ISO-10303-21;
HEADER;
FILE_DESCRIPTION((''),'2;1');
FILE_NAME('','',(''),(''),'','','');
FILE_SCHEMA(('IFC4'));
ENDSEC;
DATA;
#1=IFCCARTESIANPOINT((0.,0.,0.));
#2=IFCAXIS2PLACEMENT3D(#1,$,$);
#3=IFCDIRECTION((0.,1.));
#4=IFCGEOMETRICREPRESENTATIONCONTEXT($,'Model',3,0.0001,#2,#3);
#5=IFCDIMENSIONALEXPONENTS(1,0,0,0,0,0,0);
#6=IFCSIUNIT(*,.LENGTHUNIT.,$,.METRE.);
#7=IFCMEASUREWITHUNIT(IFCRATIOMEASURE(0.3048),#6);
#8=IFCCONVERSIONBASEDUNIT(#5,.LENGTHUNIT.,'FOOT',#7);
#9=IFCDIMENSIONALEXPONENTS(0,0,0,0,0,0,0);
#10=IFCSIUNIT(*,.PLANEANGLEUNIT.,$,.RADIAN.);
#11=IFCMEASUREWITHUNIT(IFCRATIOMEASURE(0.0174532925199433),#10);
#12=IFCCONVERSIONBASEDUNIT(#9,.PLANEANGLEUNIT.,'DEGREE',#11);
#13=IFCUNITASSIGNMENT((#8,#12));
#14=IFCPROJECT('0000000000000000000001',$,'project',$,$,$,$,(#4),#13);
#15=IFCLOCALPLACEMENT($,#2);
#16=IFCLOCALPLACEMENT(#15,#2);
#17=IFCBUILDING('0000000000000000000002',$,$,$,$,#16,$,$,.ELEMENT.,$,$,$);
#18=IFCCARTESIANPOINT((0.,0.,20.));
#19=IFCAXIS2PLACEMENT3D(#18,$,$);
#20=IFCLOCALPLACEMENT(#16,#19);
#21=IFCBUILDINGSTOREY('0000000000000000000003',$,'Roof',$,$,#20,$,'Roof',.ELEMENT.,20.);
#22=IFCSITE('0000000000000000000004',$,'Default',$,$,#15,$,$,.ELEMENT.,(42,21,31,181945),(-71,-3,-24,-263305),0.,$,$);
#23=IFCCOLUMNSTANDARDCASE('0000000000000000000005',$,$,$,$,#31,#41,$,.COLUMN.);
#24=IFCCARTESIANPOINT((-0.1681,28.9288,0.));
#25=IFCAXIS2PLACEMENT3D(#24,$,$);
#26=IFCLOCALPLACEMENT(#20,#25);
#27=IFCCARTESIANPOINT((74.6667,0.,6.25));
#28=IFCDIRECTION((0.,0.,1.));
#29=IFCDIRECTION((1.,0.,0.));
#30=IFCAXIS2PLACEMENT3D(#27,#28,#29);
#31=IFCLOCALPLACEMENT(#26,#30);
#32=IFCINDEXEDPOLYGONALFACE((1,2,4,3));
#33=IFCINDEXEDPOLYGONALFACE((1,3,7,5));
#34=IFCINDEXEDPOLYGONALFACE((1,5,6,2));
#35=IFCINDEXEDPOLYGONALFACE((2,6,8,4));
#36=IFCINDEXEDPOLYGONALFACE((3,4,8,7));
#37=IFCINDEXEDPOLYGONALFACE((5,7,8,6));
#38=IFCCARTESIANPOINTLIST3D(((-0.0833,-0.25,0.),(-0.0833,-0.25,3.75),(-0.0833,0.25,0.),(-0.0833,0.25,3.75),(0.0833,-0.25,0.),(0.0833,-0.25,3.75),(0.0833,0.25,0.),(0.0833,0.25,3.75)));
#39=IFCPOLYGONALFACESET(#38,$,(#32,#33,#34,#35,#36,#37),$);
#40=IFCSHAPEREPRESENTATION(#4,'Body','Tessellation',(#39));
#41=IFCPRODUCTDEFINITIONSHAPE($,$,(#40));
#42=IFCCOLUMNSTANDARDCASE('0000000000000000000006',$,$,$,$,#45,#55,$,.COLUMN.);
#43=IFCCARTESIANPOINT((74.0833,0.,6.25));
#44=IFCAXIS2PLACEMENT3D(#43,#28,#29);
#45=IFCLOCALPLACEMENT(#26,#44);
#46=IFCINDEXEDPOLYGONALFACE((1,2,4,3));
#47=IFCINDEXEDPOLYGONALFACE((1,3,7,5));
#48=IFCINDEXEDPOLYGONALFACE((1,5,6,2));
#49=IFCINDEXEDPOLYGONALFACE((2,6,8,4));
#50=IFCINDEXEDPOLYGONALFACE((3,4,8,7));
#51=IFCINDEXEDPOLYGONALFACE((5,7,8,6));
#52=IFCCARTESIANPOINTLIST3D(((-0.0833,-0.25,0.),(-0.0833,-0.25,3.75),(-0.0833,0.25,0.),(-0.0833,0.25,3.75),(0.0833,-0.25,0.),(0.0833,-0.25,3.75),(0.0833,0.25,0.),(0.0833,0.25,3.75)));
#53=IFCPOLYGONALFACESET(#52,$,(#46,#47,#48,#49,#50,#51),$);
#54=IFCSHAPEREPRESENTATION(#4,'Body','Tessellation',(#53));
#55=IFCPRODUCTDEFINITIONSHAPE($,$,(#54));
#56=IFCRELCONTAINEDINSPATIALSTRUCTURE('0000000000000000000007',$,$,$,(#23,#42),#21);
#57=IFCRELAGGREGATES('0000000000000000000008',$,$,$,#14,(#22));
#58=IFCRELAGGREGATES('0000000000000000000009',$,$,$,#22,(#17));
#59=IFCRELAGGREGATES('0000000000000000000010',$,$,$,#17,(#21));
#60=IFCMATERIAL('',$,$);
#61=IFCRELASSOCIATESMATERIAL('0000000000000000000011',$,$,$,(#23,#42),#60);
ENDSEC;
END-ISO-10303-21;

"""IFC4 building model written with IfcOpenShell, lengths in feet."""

from ifc_helpers import new_model, entity, si_unit, converted_unit, direction, frame, origin, place, context, project, spatial, rectangle, extrude, material, element, save


model = new_model("IFC4")

# Units and contexts
model_context = context("Model", 3, precision=0.0001, world=origin(), true_north=direction((0.0, 1.0)))
ifc_project = project(units=[converted_unit("LENGTHUNIT", "FOOT", entity("IfcRatioMeasure", 0.3048), si_unit("LENGTHUNIT", "METRE"), dimensions=[1, 0, 0, 0, 0, 0, 0]), converted_unit("PLANEANGLEUNIT", "DEGREE", entity("IfcRatioMeasure", 0.0174532925199433), si_unit("PLANEANGLEUNIT", "RADIAN"), dimensions=[0, 0, 0, 0, 0, 0, 0])], contexts=[model_context])

# Site, building, storey
site_placement = place(None, origin())
site = spatial("IfcSite", under=ifc_project, at=site_placement, Name="Default", CompositionType="ELEMENT", RefLatitude=(42, 21, 31, 181945), RefLongitude=(-71, -3, -24, -263305), RefElevation=0.0)
building_placement = place(site_placement, origin())
building = spatial("IfcBuilding", under=site, at=building_placement, CompositionType="ELEMENT")
storey_placement = place(building_placement, frame((0.0, 0.0, 20.0)))
storey = spatial("IfcBuildingStorey", under=building, at=storey_placement, Name="Roof", LongName="Roof", CompositionType="ELEMENT", Elevation=20.0)

# Columns
ifc_material_1 = material(Name="")
placement = place(storey_placement, frame((-0.1681, 28.9288, 0.0)))
for number, where, z_axis, x_axis in (
    (1, (74.6667, 0.0, 6.25), (0.0, 0.0, 1.0), (1.0, 0.0, 0.0)),
    (2, (74.0833, 0.0, 6.25), (0.0, 0.0, 1.0), (1.0, 0.0, 0.0)),
):
    element("IfcColumnStandardCase", number, at=place(placement, frame(where, z_axis=z_axis, x_axis=x_axis)), inside=storey, material=ifc_material_1, PredefinedType="COLUMN", context=model_context, shape_type="SweptSolid", body=[
        extrude(rectangle(XDim=0.1667, YDim=0.5), origin(), (0.0, 0.0, 1.0), 3.75),
    ])

save(model, "model.ifc")
